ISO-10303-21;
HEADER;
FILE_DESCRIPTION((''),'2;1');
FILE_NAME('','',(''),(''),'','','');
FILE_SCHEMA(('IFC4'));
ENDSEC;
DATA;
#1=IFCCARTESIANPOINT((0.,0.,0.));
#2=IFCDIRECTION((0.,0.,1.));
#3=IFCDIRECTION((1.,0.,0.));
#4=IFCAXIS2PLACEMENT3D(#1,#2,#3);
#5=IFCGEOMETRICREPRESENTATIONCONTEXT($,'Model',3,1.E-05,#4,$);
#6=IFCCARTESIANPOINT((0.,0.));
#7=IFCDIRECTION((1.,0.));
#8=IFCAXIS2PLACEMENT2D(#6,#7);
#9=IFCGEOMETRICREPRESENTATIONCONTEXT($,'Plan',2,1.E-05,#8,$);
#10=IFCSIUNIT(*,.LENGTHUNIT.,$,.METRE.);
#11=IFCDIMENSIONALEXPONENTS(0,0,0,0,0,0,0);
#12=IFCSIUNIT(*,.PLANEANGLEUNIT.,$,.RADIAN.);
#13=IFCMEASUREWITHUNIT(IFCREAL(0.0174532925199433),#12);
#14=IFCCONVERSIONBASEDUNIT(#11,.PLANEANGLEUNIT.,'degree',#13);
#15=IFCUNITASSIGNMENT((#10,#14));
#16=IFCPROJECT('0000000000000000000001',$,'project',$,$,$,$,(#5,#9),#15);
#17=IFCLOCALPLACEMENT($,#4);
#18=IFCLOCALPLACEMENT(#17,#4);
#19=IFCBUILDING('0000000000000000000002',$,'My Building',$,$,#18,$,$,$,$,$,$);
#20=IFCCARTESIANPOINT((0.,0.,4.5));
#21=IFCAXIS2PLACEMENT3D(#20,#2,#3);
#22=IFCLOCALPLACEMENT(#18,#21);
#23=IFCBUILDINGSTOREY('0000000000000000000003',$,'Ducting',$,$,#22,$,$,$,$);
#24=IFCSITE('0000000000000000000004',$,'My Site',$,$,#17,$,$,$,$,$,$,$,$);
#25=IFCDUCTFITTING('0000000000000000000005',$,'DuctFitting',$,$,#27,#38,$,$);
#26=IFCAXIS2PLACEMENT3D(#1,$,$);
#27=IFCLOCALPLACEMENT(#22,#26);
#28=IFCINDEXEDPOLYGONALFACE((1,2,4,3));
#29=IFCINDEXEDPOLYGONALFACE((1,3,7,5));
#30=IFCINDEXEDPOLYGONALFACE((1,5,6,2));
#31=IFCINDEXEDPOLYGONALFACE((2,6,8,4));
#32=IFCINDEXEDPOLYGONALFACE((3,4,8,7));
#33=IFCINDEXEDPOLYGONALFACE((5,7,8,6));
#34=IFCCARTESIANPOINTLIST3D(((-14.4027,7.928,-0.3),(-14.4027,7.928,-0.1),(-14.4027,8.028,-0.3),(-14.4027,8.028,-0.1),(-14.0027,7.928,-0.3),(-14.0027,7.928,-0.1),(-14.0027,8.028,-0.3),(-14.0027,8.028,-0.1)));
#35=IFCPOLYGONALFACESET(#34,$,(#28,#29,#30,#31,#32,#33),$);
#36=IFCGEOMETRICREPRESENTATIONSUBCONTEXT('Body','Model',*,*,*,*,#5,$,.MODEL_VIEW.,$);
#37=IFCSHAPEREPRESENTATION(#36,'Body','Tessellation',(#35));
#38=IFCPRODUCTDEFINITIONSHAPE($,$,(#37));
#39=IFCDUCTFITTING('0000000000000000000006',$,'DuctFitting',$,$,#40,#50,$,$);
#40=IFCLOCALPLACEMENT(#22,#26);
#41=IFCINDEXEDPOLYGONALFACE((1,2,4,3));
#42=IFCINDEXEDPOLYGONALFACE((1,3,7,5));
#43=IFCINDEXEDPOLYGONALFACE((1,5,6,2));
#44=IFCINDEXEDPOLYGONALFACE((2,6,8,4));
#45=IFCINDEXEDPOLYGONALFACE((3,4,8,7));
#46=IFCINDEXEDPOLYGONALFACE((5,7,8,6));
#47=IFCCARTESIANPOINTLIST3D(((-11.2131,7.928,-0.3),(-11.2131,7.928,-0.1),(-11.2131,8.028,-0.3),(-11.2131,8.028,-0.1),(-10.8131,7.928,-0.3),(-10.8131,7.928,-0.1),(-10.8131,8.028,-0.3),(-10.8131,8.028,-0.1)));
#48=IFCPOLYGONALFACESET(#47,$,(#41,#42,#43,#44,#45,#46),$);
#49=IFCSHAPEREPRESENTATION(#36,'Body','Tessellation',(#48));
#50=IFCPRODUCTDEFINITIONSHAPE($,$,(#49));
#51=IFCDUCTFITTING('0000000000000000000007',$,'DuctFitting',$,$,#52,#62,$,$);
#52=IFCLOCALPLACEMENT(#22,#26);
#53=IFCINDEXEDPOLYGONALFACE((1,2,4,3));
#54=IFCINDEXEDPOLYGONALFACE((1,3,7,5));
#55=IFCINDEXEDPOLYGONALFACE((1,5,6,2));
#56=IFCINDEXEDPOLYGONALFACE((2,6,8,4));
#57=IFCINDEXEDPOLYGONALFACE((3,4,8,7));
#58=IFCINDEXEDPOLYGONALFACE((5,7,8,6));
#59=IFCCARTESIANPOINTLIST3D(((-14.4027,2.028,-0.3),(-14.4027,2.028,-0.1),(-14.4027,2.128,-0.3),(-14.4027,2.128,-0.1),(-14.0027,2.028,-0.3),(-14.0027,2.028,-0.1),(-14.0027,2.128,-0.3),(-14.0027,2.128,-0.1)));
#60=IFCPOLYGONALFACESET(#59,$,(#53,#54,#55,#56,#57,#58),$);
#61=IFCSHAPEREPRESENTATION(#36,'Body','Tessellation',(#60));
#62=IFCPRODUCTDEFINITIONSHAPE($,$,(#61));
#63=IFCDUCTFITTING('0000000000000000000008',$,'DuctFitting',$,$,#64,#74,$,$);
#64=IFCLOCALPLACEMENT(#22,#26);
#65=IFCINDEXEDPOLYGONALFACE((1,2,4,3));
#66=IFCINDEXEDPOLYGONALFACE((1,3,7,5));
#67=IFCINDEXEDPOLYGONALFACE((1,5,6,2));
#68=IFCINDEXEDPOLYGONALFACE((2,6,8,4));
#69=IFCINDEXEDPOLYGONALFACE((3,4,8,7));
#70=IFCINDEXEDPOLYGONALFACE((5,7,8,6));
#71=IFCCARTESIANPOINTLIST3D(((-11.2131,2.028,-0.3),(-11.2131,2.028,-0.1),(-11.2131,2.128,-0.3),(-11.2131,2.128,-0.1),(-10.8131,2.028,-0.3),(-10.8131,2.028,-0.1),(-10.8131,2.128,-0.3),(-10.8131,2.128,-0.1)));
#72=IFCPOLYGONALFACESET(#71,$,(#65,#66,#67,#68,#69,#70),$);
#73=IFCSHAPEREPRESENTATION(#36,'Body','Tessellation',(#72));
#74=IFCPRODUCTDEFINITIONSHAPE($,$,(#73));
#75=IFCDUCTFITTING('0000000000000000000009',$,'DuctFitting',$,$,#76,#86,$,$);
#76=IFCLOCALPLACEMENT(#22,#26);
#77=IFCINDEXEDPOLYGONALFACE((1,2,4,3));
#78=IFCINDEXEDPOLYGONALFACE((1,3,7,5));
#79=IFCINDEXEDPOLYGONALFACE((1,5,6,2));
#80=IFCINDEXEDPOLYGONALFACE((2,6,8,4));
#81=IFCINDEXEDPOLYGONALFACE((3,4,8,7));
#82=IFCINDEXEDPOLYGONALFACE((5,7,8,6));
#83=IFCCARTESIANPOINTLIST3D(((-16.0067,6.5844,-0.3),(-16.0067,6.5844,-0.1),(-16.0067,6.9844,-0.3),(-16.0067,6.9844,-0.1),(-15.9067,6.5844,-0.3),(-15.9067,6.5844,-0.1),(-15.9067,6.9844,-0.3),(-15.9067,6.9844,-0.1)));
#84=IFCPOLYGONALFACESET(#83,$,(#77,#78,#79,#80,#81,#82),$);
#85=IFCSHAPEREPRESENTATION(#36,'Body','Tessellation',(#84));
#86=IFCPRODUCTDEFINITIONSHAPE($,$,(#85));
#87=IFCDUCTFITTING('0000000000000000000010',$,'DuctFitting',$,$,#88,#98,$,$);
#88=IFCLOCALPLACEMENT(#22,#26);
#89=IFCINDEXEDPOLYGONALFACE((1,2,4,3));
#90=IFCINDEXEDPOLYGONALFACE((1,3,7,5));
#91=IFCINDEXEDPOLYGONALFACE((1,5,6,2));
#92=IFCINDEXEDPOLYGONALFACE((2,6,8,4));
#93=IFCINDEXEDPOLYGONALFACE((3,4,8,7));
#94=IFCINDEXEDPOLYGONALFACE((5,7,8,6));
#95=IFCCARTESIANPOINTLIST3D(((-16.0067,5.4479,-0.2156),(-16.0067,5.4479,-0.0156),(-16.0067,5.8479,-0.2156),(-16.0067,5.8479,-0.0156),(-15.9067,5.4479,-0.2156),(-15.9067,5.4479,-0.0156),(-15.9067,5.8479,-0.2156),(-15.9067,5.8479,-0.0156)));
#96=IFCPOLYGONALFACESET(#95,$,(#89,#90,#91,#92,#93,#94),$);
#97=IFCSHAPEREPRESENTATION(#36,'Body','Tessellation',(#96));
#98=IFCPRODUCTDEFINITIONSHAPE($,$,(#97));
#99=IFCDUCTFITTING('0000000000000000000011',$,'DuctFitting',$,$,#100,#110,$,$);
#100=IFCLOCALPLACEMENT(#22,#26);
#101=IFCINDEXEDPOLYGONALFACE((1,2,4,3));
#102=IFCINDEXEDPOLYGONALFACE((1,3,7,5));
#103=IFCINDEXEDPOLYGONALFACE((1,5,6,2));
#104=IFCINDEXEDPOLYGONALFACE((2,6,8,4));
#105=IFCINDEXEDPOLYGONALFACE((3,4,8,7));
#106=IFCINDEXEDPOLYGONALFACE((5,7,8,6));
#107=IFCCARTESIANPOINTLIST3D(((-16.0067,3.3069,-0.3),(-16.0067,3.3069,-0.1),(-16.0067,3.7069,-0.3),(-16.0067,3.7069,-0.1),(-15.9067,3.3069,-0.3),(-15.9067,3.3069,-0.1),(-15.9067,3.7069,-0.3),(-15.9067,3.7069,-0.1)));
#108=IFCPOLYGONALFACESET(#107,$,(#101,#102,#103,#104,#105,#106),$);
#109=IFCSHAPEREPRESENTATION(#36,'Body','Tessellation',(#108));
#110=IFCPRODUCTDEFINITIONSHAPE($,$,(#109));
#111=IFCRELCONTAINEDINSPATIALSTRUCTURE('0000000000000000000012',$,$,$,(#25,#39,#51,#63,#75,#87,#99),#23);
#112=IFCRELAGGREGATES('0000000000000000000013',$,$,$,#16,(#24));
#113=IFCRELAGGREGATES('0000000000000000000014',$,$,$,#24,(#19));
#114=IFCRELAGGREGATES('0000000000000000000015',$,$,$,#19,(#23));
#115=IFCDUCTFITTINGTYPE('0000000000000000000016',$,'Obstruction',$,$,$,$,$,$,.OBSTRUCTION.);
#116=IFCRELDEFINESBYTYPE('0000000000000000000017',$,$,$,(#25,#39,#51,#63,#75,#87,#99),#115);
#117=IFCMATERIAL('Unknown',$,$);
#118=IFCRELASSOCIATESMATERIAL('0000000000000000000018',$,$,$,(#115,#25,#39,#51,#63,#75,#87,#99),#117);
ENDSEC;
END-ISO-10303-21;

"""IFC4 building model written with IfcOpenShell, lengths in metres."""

from ifc_helpers import new_model, entity, si_unit, converted_unit, frame, origin_with_axes, origin_2d_with_axis, place, context, subcontext, project, spatial, rectangle, extrude, material, material_profile, profile_set, profile_usage, type_object, element, save


model = new_model("IFC4")

# Units and contexts
model_context = context("Model", 3, precision=1e-05, world=origin_with_axes())
plan_context = context("Plan", 2, precision=1e-05, world=origin_2d_with_axis())
body_context = subcontext(model_context, "Body", "Model", "MODEL_VIEW")
ifc_project = project(units=[si_unit("LENGTHUNIT", "METRE"), converted_unit("PLANEANGLEUNIT", "degree", entity("IfcReal", 0.0174532925199433), si_unit("PLANEANGLEUNIT", "RADIAN"), dimensions=[0, 0, 0, 0, 0, 0, 0])], contexts=[model_context, plan_context])

# Site, building, storey
site_placement = place(None, origin_with_axes())
site = spatial("IfcSite", under=ifc_project, at=site_placement, Name="My Site")
building_placement = place(site_placement, origin_with_axes())
building = spatial("IfcBuilding", under=site, at=building_placement, Name="My Building")
storey_placement = place(building_placement, frame((0.0, 0.0, 4.5), z_axis=(0.0, 0.0, 1.0), x_axis=(1.0, 0.0, 0.0)))
storey = spatial("IfcBuildingStorey", under=building, at=storey_placement, Name="Ducting")

# Shared definitions
ifc_material = material(Name="Unknown")

# Duct fittings
ifc_material_profile_1 = material_profile(ifc_material, rectangle(XDim=0.4, YDim=0.2))
ifc_profile_set_1 = profile_set([ifc_material_profile_1])
duct_fitting_type_1 = type_object("IfcDuctFittingType", Name="Obstruction", PredefinedType="OBSTRUCTION", material=ifc_profile_set_1)
ifc_profile_usage_1 = profile_usage(ifc_profile_set_1, cardinal=5)
duct_fitting_1_placement = place(storey_placement, frame((-14.2027, 7.928, -0.2), z_axis=(0.0, 1.0, 0.0), x_axis=(-1.0, 0.0, 0.0)))
element("IfcDuctFitting", 1, at=duct_fitting_1_placement, inside=storey, type_object=duct_fitting_type_1, material=ifc_profile_usage_1, Name="DuctFitting", context=body_context, shape_type="SweptSolid", body=[
    extrude(rectangle(XDim=0.4, YDim=0.2), origin_with_axes(), (0.0, 0.0, 1.0), 0.1),
])
ifc_profile_usage_2 = profile_usage(ifc_profile_set_1, cardinal=5)
duct_fitting_2_placement = place(storey_placement, frame((-11.0131, 7.928, -0.2), z_axis=(0.0, 1.0, 0.0), x_axis=(-1.0, 0.0, 0.0)))
element("IfcDuctFitting", 2, at=duct_fitting_2_placement, inside=storey, type_object=duct_fitting_type_1, material=ifc_profile_usage_2, Name="DuctFitting", context=body_context, shape_type="SweptSolid", body=[
    extrude(rectangle(XDim=0.4, YDim=0.2), origin_with_axes(), (0.0, 0.0, 1.0), 0.1),
])
ifc_profile_usage_3 = profile_usage(ifc_profile_set_1, cardinal=5)
duct_fitting_3_placement = place(storey_placement, frame((-14.2027, 2.028, -0.2), z_axis=(0.0, 1.0, 0.0), x_axis=(-1.0, 0.0, 0.0)))
element("IfcDuctFitting", 3, at=duct_fitting_3_placement, inside=storey, type_object=duct_fitting_type_1, material=ifc_profile_usage_3, Name="DuctFitting", context=body_context, shape_type="SweptSolid", body=[
    extrude(rectangle(XDim=0.4, YDim=0.2), origin_with_axes(), (0.0, 0.0, 1.0), 0.1),
])
ifc_profile_usage_4 = profile_usage(ifc_profile_set_1, cardinal=5)
duct_fitting_4_placement = place(storey_placement, frame((-11.0131, 2.028, -0.2), z_axis=(0.0, 1.0, 0.0), x_axis=(-1.0, 0.0, 0.0)))
element("IfcDuctFitting", 4, at=duct_fitting_4_placement, inside=storey, type_object=duct_fitting_type_1, material=ifc_profile_usage_4, Name="DuctFitting", context=body_context, shape_type="SweptSolid", body=[
    extrude(rectangle(XDim=0.4, YDim=0.2), origin_with_axes(), (0.0, 0.0, 1.0), 0.1),
])
ifc_profile_usage_5 = profile_usage(ifc_profile_set_1, cardinal=5)
duct_fitting_5_placement = place(storey_placement, frame((-15.9067, 6.7844, -0.2), z_axis=(-1.0, 0.0, 0.0), x_axis=(0.0, -1.0, 0.0)))
element("IfcDuctFitting", 5, at=duct_fitting_5_placement, inside=storey, type_object=duct_fitting_type_1, material=ifc_profile_usage_5, Name="DuctFitting", context=body_context, shape_type="SweptSolid", body=[
    extrude(rectangle(XDim=0.4, YDim=0.2), origin_with_axes(), (0.0, 0.0, 1.0), 0.1),
])
ifc_profile_usage_6 = profile_usage(ifc_profile_set_1, cardinal=5)
duct_fitting_6_placement = place(storey_placement, frame((-15.9067, 5.6479, -0.1156), z_axis=(-1.0, 0.0, 0.0), x_axis=(0.0, -1.0, 0.0)))
element("IfcDuctFitting", 6, at=duct_fitting_6_placement, inside=storey, type_object=duct_fitting_type_1, material=ifc_profile_usage_6, Name="DuctFitting", context=body_context, shape_type="SweptSolid", body=[
    extrude(rectangle(XDim=0.4, YDim=0.2), origin_with_axes(), (0.0, 0.0, 1.0), 0.1),
])
ifc_profile_usage_7 = profile_usage(ifc_profile_set_1, cardinal=5)
duct_fitting_7_placement = place(storey_placement, frame((-15.9067, 3.5069, -0.2), z_axis=(-1.0, 0.0, 0.0), x_axis=(0.0, -1.0, 0.0)))
element("IfcDuctFitting", 7, at=duct_fitting_7_placement, inside=storey, type_object=duct_fitting_type_1, material=ifc_profile_usage_7, Name="DuctFitting", context=body_context, shape_type="SweptSolid", body=[
    extrude(rectangle(XDim=0.4, YDim=0.2), origin_with_axes(), (0.0, 0.0, 1.0), 0.1),
])

save(model, "model.ifc")
